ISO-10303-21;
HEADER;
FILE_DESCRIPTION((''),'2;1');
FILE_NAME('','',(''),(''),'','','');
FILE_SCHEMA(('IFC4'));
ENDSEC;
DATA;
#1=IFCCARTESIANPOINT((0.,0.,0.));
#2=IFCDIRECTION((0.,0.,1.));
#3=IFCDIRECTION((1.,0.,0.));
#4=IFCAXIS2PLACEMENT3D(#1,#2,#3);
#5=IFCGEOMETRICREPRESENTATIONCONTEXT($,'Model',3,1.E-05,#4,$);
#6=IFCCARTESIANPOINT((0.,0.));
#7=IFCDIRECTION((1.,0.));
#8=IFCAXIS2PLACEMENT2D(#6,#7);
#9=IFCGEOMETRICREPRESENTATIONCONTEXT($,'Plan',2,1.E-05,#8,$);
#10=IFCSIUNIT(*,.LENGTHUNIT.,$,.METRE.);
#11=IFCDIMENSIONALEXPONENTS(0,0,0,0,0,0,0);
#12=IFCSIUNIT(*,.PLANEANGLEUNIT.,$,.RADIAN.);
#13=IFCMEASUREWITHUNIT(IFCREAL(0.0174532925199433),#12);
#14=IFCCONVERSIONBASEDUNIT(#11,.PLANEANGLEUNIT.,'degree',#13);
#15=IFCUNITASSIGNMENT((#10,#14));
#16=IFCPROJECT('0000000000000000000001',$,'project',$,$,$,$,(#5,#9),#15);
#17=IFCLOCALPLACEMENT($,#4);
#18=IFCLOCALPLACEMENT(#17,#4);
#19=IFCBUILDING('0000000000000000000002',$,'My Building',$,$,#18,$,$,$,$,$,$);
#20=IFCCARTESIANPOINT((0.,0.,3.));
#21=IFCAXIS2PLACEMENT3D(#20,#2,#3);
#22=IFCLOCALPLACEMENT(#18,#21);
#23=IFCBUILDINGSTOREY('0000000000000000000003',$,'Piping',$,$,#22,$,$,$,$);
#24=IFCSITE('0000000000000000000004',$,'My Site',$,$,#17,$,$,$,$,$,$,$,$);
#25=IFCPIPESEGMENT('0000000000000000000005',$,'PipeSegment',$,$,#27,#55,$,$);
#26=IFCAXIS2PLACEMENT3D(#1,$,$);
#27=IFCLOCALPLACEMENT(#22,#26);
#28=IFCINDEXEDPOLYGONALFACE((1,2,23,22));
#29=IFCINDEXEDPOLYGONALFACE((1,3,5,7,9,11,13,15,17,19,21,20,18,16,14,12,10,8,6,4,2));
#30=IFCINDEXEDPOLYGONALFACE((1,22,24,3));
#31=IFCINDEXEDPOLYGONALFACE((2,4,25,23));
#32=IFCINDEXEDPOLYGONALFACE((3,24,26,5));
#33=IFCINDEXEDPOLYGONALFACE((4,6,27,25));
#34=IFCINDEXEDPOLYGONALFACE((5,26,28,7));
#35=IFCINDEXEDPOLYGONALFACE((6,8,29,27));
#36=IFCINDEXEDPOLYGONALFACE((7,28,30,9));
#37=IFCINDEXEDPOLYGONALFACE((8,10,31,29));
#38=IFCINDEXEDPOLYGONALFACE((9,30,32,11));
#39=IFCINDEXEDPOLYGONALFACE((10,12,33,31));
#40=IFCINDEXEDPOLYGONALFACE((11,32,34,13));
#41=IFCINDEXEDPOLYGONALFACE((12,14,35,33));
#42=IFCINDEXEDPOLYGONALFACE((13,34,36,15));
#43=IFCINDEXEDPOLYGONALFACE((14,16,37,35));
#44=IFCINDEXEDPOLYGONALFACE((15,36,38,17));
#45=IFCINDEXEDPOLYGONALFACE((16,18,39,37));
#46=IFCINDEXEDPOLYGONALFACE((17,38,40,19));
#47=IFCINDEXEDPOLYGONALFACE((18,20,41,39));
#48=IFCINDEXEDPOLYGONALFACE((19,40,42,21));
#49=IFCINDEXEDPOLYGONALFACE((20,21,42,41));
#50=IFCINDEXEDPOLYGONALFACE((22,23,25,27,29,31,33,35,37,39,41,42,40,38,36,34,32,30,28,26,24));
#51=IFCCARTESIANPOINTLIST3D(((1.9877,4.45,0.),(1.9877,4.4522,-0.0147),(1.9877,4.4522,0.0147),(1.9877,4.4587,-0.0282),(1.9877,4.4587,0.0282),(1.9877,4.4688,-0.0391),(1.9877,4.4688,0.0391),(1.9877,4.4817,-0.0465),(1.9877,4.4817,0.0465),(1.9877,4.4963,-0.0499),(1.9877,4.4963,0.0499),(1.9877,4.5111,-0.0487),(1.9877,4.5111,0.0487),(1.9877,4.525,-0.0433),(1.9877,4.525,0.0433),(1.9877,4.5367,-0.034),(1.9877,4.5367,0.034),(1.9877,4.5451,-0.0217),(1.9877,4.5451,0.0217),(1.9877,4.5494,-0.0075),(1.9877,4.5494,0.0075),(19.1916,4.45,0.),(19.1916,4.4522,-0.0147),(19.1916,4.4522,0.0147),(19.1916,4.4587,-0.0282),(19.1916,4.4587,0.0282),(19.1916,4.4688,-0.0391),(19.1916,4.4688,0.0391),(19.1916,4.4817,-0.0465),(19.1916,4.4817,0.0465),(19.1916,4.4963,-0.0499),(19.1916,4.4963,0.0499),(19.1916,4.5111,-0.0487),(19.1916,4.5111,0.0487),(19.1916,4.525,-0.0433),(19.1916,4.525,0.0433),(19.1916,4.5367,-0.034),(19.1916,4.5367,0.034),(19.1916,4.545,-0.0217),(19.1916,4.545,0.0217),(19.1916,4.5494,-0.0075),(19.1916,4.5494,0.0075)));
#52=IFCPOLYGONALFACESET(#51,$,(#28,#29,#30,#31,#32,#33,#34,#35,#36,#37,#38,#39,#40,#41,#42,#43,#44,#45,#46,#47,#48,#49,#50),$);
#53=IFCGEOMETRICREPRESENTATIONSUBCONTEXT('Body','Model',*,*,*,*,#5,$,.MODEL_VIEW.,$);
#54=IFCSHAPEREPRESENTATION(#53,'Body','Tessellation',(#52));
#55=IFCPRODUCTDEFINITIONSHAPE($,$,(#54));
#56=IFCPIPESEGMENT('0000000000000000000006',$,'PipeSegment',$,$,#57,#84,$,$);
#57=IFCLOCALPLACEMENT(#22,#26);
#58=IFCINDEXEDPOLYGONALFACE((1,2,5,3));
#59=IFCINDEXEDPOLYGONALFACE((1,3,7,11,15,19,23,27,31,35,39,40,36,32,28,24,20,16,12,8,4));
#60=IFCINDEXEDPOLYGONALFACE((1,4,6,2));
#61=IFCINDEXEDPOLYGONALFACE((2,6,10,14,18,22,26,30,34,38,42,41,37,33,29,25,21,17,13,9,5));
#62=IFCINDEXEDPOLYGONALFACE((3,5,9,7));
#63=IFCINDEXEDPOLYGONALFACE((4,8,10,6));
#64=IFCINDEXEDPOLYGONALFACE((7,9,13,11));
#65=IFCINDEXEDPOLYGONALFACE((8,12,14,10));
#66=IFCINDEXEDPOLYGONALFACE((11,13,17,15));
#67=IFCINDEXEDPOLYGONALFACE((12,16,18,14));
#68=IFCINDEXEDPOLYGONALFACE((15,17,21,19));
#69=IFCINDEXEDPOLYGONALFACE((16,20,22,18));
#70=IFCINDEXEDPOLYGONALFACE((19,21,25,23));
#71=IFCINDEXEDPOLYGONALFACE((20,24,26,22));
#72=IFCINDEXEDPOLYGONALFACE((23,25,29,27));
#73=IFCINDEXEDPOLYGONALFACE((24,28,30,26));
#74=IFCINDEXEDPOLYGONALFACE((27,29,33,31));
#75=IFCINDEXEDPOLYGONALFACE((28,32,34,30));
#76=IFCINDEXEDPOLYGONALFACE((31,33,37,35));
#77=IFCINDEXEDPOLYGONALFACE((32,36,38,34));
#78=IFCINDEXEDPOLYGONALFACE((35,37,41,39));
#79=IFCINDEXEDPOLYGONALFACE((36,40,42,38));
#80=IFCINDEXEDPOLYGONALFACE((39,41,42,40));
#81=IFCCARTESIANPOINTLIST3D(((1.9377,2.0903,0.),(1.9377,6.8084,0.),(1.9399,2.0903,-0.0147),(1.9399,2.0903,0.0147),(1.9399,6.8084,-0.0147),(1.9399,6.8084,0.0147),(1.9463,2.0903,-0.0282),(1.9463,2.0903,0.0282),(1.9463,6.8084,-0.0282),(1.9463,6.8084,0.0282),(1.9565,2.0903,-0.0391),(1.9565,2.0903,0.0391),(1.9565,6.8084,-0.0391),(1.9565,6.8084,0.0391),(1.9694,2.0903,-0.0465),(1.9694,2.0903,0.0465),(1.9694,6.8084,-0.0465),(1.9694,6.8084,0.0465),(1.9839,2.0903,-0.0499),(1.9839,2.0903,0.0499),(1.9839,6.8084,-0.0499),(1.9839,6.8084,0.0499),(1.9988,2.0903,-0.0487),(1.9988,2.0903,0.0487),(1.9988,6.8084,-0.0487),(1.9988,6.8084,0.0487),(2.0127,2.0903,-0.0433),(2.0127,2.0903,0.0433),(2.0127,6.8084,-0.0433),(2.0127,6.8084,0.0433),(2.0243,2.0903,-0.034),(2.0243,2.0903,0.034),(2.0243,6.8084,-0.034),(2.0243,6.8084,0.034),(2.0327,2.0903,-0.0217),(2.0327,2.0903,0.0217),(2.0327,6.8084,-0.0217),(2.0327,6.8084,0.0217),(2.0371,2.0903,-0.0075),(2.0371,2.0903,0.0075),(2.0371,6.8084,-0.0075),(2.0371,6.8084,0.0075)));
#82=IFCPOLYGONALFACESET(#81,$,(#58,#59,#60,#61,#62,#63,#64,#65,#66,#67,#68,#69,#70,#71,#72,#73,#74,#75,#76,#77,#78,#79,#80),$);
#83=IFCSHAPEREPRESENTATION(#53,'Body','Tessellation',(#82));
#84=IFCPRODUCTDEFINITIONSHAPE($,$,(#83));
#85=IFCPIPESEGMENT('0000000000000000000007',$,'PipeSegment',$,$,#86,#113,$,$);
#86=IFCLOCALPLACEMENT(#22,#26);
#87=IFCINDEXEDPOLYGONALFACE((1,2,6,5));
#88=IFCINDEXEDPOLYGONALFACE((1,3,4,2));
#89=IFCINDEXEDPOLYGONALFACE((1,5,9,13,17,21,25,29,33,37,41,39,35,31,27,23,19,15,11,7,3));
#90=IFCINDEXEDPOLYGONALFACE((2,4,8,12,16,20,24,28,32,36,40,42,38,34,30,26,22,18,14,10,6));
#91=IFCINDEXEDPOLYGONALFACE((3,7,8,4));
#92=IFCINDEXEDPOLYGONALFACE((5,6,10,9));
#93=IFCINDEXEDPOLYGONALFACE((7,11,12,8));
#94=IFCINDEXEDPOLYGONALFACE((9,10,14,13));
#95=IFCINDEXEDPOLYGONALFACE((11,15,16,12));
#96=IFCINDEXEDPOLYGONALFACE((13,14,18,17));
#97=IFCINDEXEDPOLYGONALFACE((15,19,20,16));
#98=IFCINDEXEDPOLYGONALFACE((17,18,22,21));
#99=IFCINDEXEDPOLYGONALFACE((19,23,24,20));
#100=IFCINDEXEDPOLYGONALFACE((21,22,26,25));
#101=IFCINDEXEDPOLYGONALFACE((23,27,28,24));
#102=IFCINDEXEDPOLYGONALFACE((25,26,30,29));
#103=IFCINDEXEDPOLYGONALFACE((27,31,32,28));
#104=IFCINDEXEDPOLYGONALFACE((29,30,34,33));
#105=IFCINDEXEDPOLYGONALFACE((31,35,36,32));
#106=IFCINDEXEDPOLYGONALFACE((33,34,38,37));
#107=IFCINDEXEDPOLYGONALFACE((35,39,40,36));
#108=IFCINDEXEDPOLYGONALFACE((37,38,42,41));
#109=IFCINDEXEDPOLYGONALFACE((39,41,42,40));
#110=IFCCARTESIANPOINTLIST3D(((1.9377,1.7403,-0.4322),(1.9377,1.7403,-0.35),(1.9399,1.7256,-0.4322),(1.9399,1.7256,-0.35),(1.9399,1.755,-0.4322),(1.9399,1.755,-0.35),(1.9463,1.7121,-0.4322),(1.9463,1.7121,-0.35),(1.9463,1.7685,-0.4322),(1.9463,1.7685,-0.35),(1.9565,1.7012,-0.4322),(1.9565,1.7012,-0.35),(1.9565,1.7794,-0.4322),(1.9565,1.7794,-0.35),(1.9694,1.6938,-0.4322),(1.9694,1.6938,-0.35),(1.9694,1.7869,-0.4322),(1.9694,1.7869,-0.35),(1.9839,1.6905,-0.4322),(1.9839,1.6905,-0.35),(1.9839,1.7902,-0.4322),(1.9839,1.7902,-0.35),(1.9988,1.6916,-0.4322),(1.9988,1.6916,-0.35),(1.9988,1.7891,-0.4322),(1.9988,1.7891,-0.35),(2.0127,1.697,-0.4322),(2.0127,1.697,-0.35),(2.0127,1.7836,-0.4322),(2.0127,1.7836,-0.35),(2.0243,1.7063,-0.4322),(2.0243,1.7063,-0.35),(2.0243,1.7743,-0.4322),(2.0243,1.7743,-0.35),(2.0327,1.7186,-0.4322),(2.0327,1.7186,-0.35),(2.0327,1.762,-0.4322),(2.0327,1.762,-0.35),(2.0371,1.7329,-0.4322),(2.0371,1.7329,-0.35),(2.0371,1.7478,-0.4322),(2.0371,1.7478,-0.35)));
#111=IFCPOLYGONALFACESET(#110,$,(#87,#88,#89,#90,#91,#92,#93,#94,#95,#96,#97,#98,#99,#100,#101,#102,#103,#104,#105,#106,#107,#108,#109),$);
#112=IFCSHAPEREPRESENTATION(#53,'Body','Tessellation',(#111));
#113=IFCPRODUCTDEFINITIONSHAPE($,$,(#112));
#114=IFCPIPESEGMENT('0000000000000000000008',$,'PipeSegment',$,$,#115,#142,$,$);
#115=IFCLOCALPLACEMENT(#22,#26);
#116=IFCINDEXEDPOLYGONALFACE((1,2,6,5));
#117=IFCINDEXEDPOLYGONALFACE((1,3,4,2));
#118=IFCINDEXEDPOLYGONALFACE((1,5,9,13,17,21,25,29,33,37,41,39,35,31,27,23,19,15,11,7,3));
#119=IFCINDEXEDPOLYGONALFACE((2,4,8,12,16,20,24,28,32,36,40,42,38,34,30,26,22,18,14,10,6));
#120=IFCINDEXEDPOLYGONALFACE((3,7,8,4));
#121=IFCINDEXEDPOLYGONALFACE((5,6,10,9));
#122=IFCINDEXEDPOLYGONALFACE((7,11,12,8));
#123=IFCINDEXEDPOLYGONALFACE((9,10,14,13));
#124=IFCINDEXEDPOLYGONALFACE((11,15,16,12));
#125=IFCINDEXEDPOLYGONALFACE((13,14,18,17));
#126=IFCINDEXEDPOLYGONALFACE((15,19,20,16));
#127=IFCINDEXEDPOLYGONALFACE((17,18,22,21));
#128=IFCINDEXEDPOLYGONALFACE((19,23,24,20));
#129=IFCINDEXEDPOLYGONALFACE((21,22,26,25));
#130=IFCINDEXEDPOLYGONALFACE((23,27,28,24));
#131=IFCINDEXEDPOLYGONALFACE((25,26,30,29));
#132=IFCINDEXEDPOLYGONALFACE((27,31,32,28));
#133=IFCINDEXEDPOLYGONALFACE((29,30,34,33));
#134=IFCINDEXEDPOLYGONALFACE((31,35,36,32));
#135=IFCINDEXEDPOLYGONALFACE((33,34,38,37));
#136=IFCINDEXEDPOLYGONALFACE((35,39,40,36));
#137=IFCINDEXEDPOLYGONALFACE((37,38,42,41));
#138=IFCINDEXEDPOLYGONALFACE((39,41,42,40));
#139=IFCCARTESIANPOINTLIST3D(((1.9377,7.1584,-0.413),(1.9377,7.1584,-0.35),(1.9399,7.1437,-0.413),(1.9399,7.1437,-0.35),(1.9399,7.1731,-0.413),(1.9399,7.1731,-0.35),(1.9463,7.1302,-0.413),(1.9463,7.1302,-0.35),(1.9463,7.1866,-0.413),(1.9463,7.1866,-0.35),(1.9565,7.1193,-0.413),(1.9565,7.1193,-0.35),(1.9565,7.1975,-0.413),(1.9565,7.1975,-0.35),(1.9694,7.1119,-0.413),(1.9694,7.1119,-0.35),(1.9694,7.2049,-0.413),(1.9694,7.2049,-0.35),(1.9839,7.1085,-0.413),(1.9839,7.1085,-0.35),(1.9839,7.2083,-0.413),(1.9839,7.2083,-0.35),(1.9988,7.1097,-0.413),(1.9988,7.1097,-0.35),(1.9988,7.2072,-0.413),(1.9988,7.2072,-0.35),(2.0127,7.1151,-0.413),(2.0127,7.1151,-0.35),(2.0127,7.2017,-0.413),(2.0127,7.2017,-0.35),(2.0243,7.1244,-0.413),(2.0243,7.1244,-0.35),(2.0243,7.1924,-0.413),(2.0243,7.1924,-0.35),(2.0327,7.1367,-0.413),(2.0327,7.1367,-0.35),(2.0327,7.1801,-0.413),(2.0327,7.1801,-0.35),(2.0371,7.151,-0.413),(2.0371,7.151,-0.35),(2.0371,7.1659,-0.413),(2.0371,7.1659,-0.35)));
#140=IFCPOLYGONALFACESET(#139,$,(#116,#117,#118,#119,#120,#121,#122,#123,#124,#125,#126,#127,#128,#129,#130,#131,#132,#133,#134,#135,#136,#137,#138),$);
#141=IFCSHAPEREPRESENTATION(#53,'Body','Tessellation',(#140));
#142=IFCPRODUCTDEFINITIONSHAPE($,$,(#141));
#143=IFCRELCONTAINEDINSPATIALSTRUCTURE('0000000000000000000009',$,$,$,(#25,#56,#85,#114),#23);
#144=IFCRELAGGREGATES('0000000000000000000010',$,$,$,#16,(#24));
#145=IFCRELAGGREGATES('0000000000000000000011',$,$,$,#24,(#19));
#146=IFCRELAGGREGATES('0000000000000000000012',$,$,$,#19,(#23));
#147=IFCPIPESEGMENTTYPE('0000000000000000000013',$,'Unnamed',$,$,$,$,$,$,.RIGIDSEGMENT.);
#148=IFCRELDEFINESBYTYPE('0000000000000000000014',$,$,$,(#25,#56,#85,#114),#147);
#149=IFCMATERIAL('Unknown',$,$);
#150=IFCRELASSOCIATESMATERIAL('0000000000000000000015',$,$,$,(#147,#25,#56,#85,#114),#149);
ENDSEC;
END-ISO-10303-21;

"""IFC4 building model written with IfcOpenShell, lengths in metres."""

from ifc_helpers import new_model, entity, si_unit, converted_unit, frame, origin_with_axes, origin_2d_with_axis, place, context, subcontext, project, spatial, circle, extrude, material, material_profile, profile_set, profile_usage, type_object, element, save


model = new_model("IFC4")

# Units and contexts
model_context = context("Model", 3, precision=1e-05, world=origin_with_axes())
plan_context = context("Plan", 2, precision=1e-05, world=origin_2d_with_axis())
body_context = subcontext(model_context, "Body", "Model", "MODEL_VIEW")
ifc_project = project(units=[si_unit("LENGTHUNIT", "METRE"), converted_unit("PLANEANGLEUNIT", "degree", entity("IfcReal", 0.0174532925199433), si_unit("PLANEANGLEUNIT", "RADIAN"), dimensions=[0, 0, 0, 0, 0, 0, 0])], contexts=[model_context, plan_context])

# Site, building, storey
site_placement = place(None, origin_with_axes())
site = spatial("IfcSite", under=ifc_project, at=site_placement, Name="My Site")
building_placement = place(site_placement, origin_with_axes())
building = spatial("IfcBuilding", under=site, at=building_placement, Name="My Building")
storey_placement = place(building_placement, frame((0.0, 0.0, 3.0), z_axis=(0.0, 0.0, 1.0), x_axis=(1.0, 0.0, 0.0)))
storey = spatial("IfcBuildingStorey", under=building, at=storey_placement, Name="Piping")

# Pipe segments
ifc_material = material(Name="Unknown")
ifc_material_profile = material_profile(ifc_material, circle(Radius=0.05))
ifc_profile_set = profile_set([ifc_material_profile])
ifc_profile_usage_1 = profile_usage(ifc_profile_set, cardinal=5)
pipe_segment_type = type_object("IfcPipeSegmentType", Name="Unnamed", PredefinedType="RIGIDSEGMENT", material=ifc_profile_set)
pipe_segment_1_placement = place(storey_placement, frame((19.1916, 4.5, 0.0), z_axis=(-1.0, 0.0, 0.0), x_axis=(0.0, -1.0, 0.0)))
element("IfcPipeSegment", 1, at=pipe_segment_1_placement, inside=storey, type_object=pipe_segment_type, material=ifc_profile_usage_1, Name="PipeSegment", context=body_context, shape_type="SweptSolid", body=[
    extrude(circle(Radius=0.05), origin_with_axes(), (0.0, 0.0, 1.0), 17.2039),
])
ifc_profile_usage_2 = profile_usage(ifc_profile_set, cardinal=5)
pipe_segment_2_placement = place(storey_placement, frame((1.9877, 2.0903, 0.0), z_axis=(0.0, 1.0, 0.0), x_axis=(-1.0, 0.0, 0.0)))
element("IfcPipeSegment", 2, at=pipe_segment_2_placement, inside=storey, type_object=pipe_segment_type, material=ifc_profile_usage_2, Name="PipeSegment", context=body_context, shape_type="SweptSolid", body=[
    extrude(circle(Radius=0.05), origin_with_axes(), (0.0, 0.0, 1.0), 4.7181),
])
ifc_profile_usage_3 = profile_usage(ifc_profile_set, cardinal=5)
pipe_segment_3_placement = place(storey_placement, frame((1.9877, 1.7403, -0.35), z_axis=(0.0, 0.0, -1.0), x_axis=(-1.0, 0.0, 0.0)))
element("IfcPipeSegment", 3, at=pipe_segment_3_placement, inside=storey, type_object=pipe_segment_type, material=ifc_profile_usage_3, Name="PipeSegment", context=body_context, shape_type="SweptSolid", body=[
    extrude(circle(Radius=0.05), origin_with_axes(), (0.0, 0.0, 1.0), 0.0822),
])
ifc_profile_usage_4 = profile_usage(ifc_profile_set, cardinal=5)
pipe_segment_4_placement = place(storey_placement, frame((1.9877, 7.1584, -0.35), z_axis=(0.0, 0.0, -1.0), x_axis=(-1.0, 0.0, 0.0)))
element("IfcPipeSegment", 4, at=pipe_segment_4_placement, inside=storey, type_object=pipe_segment_type, material=ifc_profile_usage_4, Name="PipeSegment", context=body_context, shape_type="SweptSolid", body=[
    extrude(circle(Radius=0.05), origin_with_axes(), (0.0, 0.0, 1.0), 0.063),
])

save(model, "model.ifc")
